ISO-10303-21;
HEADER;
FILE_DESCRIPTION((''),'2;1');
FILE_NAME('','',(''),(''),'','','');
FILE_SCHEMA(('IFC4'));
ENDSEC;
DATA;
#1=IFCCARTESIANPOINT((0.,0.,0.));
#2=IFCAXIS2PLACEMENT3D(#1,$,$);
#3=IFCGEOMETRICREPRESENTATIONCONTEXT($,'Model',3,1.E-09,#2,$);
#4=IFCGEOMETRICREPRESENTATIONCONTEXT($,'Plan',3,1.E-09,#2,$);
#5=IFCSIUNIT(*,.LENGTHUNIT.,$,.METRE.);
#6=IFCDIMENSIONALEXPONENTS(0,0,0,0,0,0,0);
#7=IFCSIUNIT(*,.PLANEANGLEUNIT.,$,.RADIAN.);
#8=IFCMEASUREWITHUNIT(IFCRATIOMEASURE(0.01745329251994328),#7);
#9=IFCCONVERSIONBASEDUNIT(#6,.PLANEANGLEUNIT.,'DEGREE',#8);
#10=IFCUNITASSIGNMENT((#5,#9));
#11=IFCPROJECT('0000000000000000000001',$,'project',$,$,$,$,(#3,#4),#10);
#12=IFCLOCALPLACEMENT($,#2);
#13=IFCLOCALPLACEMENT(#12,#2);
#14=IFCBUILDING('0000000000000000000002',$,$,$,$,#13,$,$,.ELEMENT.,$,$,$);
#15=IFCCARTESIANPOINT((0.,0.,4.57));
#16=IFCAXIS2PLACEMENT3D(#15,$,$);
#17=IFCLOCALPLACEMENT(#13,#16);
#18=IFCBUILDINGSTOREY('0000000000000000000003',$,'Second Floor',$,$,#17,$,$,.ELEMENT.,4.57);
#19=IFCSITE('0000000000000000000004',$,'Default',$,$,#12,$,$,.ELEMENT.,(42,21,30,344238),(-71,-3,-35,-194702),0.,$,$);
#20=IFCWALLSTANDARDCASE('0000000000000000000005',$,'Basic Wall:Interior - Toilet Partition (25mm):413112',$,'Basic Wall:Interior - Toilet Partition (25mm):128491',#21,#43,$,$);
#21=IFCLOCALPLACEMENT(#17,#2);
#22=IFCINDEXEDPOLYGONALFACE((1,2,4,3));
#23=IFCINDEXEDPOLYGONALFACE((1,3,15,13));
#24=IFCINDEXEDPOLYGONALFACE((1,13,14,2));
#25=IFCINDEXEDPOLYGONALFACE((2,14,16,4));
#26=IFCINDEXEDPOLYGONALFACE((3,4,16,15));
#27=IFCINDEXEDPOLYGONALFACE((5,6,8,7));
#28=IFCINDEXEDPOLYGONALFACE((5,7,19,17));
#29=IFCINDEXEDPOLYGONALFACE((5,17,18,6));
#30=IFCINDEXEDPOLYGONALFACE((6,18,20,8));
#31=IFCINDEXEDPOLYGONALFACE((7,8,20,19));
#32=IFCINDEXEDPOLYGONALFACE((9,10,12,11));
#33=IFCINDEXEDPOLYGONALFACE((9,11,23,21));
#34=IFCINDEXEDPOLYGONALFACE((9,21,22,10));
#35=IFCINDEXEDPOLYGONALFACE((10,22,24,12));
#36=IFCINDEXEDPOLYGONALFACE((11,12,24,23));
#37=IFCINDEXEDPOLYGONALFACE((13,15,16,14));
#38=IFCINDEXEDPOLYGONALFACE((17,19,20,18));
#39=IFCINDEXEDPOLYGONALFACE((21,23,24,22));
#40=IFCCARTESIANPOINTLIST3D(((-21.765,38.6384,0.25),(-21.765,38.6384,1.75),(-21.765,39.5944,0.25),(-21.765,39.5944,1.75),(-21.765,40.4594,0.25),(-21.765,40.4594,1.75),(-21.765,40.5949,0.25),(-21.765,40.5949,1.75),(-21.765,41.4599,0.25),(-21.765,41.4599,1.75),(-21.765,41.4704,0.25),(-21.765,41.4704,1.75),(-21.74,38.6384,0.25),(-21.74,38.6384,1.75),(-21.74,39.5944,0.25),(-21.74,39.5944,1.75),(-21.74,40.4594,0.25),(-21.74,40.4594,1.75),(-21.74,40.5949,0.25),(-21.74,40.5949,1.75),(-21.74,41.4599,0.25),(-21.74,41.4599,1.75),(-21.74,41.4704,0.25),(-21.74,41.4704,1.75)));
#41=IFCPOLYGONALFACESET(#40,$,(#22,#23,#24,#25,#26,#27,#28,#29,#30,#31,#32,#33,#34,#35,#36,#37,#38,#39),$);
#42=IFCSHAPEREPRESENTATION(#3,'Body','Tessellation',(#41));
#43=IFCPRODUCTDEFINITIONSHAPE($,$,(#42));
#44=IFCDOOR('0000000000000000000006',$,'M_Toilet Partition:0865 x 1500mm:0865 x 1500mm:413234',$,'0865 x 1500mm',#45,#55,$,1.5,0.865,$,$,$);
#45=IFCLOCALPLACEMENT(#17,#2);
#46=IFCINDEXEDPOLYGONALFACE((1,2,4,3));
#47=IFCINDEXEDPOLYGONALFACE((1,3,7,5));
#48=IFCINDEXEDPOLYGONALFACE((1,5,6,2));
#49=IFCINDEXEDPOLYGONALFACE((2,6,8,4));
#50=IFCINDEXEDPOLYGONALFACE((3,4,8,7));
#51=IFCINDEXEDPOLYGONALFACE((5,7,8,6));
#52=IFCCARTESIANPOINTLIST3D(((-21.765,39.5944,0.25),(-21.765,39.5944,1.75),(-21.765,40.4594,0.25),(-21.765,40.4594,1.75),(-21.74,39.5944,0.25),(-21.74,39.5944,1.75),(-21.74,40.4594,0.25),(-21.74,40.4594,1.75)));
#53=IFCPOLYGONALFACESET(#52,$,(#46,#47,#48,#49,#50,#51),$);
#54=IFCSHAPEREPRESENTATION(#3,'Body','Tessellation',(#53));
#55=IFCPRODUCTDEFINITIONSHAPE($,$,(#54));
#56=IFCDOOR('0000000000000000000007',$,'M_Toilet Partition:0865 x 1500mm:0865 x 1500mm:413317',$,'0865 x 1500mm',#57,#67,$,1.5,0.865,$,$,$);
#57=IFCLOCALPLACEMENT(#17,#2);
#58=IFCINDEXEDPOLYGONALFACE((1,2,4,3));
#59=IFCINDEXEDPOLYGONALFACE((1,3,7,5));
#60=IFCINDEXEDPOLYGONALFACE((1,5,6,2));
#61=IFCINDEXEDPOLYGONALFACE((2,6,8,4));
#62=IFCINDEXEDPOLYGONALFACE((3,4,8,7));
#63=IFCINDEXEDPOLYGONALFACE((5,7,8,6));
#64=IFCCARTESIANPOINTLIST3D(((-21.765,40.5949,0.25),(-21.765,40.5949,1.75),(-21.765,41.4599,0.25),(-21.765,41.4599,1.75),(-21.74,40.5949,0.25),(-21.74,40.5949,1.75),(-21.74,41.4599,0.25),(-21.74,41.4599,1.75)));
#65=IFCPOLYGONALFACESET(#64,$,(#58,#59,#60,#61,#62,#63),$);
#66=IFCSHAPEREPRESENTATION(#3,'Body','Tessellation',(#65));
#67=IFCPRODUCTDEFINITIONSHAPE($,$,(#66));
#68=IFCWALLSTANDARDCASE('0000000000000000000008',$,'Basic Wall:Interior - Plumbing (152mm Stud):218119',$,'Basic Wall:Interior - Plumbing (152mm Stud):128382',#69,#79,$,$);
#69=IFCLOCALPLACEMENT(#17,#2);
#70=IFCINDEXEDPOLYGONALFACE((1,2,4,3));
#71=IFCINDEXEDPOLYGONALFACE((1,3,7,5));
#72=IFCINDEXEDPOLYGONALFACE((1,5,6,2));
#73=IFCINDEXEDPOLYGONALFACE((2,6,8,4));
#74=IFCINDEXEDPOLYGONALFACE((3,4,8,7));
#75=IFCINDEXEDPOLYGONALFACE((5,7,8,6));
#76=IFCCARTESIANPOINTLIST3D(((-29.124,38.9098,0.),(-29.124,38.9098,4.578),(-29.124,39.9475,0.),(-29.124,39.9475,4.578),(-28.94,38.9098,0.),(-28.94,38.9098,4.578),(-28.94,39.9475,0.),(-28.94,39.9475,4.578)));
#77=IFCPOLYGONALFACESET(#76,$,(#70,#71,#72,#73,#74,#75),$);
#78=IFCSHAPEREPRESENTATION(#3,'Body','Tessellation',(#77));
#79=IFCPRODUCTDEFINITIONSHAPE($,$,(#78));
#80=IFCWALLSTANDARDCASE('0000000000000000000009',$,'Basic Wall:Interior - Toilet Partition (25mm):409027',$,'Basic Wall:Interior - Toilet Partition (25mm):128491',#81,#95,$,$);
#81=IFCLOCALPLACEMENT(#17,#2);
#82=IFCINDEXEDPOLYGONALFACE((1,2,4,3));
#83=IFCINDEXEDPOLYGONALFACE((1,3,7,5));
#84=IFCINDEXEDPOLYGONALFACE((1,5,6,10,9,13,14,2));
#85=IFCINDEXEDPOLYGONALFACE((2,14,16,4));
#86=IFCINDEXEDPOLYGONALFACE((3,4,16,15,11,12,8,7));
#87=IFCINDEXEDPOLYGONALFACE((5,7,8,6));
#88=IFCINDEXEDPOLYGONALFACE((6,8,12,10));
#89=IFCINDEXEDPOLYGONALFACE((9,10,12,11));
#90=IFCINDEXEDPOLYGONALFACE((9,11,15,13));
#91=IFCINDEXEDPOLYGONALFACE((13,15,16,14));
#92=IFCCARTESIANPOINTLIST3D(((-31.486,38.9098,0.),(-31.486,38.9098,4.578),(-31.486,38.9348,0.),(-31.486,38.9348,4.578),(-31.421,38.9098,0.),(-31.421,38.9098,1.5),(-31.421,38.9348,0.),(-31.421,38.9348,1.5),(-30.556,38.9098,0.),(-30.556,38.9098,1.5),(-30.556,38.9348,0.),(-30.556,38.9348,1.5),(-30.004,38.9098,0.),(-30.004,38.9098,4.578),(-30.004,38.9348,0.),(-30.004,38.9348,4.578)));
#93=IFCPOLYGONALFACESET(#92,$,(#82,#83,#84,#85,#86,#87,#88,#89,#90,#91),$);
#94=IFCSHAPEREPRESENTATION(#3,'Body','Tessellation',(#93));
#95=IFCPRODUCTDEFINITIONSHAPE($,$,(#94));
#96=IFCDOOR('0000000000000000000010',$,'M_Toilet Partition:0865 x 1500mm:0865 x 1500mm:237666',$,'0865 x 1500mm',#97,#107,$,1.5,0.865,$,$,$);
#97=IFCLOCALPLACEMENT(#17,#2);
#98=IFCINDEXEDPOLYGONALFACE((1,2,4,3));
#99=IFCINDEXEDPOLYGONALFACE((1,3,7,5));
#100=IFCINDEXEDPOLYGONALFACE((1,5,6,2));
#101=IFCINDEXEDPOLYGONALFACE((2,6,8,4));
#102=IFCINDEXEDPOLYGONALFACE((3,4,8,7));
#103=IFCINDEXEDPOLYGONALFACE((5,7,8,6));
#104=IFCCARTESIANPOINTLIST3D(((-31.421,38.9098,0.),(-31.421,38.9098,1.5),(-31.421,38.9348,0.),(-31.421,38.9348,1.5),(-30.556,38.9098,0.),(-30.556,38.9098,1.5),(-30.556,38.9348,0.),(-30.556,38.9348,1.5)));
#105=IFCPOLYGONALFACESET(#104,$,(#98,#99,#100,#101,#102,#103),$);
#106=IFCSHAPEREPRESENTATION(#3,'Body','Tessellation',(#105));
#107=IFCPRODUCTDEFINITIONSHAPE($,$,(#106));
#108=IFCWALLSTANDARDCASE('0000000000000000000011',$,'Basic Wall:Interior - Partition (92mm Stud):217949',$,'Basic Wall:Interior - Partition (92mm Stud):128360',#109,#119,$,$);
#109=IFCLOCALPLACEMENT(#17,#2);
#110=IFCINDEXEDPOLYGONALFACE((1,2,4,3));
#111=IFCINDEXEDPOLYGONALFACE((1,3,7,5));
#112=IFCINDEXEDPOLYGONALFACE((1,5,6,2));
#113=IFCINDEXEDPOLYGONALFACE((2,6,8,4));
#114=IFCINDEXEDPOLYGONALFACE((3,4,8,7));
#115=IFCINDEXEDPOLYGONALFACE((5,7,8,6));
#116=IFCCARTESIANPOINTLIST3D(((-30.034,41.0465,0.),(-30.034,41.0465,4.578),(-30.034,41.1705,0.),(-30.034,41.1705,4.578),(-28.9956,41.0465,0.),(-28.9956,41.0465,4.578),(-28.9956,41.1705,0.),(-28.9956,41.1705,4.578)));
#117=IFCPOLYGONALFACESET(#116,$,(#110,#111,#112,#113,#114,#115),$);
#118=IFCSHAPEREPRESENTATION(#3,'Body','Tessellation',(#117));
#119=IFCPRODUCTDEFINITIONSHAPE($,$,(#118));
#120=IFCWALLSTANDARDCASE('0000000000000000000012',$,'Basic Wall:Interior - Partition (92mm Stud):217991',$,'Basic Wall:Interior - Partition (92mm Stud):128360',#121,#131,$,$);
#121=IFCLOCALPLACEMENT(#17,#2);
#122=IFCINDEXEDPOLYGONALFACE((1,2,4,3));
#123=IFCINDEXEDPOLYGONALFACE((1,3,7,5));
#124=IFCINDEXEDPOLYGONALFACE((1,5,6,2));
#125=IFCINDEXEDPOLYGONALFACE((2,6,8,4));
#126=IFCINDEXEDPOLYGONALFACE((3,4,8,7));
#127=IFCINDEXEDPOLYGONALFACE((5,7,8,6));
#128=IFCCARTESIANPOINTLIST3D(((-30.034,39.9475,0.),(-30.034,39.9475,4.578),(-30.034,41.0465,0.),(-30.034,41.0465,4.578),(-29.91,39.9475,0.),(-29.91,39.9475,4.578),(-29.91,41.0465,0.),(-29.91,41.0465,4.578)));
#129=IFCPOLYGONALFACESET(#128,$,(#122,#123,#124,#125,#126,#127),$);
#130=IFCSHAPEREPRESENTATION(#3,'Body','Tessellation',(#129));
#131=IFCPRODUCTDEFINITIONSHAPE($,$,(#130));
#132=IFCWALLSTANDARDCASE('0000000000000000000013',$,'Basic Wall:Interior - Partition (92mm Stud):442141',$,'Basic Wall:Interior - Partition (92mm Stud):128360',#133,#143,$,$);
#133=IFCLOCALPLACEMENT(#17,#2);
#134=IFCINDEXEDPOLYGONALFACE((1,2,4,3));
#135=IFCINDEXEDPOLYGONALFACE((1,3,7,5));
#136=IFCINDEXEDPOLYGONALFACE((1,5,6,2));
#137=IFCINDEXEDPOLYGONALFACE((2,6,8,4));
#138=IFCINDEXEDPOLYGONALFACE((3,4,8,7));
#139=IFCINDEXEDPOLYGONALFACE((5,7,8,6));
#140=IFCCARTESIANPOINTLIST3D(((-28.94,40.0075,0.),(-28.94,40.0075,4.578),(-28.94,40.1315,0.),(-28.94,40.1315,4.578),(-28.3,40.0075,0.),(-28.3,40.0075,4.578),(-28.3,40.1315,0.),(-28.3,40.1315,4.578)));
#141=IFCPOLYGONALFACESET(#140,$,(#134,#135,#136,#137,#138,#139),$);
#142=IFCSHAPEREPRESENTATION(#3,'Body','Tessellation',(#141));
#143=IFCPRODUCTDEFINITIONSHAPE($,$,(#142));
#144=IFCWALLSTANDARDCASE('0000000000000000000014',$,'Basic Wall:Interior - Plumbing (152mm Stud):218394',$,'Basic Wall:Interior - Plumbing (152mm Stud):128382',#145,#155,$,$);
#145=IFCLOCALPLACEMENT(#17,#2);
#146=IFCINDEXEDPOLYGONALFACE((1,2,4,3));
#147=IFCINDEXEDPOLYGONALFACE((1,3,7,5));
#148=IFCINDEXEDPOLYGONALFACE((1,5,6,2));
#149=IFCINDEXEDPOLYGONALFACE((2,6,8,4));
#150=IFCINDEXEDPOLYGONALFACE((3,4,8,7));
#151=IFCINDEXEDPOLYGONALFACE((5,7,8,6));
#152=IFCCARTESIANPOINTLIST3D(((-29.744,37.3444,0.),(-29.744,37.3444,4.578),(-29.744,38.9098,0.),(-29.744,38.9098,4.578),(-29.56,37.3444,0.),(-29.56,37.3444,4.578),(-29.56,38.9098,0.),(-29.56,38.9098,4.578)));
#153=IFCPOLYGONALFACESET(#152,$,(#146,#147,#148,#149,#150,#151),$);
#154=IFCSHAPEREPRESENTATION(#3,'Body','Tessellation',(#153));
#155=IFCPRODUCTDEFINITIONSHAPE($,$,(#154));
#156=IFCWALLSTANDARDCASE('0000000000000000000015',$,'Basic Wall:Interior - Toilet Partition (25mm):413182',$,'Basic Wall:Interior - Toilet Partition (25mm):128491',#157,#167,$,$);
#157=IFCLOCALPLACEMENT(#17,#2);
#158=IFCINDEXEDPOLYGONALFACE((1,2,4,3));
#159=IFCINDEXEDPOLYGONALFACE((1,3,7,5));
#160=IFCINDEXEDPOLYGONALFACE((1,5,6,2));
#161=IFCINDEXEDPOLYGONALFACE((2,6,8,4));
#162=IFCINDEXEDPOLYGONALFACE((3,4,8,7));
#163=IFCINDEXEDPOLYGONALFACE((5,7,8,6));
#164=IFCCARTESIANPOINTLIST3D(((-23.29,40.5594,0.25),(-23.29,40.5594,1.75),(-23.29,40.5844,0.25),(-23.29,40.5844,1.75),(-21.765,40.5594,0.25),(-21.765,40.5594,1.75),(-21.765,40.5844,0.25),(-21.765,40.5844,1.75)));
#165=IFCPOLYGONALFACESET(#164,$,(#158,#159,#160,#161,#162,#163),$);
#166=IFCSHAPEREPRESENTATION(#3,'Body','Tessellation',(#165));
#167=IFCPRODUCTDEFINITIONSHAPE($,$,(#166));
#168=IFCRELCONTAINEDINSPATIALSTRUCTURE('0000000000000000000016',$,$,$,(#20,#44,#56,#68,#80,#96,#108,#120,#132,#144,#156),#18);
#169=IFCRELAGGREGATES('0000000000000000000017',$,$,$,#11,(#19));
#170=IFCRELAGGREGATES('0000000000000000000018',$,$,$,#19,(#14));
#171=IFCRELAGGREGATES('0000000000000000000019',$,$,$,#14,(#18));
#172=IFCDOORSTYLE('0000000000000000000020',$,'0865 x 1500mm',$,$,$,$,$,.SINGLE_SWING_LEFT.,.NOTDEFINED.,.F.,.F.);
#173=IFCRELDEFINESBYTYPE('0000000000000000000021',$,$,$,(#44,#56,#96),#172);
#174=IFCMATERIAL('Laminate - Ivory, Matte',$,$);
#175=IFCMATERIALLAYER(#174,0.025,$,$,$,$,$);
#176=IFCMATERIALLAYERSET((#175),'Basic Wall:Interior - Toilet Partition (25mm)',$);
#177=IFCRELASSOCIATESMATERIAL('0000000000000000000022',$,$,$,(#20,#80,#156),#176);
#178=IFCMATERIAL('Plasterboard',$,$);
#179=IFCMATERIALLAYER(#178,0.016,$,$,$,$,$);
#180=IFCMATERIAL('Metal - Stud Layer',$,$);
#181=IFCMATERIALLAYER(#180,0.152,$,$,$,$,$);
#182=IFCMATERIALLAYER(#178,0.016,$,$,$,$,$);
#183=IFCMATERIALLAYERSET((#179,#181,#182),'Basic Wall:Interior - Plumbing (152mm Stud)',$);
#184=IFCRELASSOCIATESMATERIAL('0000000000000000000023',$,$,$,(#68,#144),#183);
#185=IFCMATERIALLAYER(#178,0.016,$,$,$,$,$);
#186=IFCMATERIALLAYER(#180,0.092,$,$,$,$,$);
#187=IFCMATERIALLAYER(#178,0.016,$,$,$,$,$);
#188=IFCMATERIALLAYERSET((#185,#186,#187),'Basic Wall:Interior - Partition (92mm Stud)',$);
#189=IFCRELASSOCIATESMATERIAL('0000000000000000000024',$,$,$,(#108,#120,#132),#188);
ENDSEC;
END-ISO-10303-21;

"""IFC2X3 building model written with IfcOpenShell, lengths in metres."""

from ifc_helpers import new_model, entity, si_unit, converted_unit, frame, frame_2d, origin, origin_2d_with_axis, place, context, project, spatial, rectangle, extrude, source, transform, mapped, material, layer, layer_set, layer_usage, type_object, type_shapes, element, fill, save


model = new_model("IFC2X3")

# Units and contexts
model_context = context("Model", 3, precision=1e-09, world=origin())
plan_context = context("Plan", 3, precision=1e-09, world=origin())
ifc_project = project(units=[si_unit("LENGTHUNIT", "METRE"), converted_unit("PLANEANGLEUNIT", "DEGREE", entity("IfcRatioMeasure", 0.01745329251994328), si_unit("PLANEANGLEUNIT", "RADIAN"), dimensions=[0, 0, 0, 0, 0, 0, 0])], contexts=[model_context, plan_context])

# Site, building, storey
site_placement = place(None, origin())
site = spatial("IfcSite", under=ifc_project, at=site_placement, Name="Default", CompositionType="ELEMENT", RefLatitude=(42, 21, 30, 344238), RefLongitude=(-71, -3, -35, -194702), RefElevation=0.0)
building_placement = place(site_placement, origin())
building = spatial("IfcBuilding", under=site, at=building_placement, CompositionType="ELEMENT")
storey_placement = place(building_placement, frame((0.0, 0.0, 4.57)))
storey = spatial("IfcBuildingStorey", under=building, at=storey_placement, Name="Second Floor", CompositionType="ELEMENT", Elevation=4.57)

# Shared definitions
ifc_material_1 = material(Name="Plasterboard")
ifc_layer_1 = layer(ifc_material_1, 0.016)
ifc_material_2 = material(Name="Metal - Stud Layer")
ifc_layer_2 = layer(ifc_material_2, 0.092)
ifc_layer_3 = layer(ifc_material_1, 0.016)
ifc_layer_set_1 = layer_set([ifc_layer_1, ifc_layer_2, ifc_layer_3], Name="Basic Wall:Interior - Partition (92mm Stud)")
ifc_layer_usage_1 = layer_usage(ifc_layer_set_1, "AXIS2", "NEGATIVE", 0.062)

# Shared definitions
ifc_layer_4 = layer(ifc_material_1, 0.016)
ifc_layer_5 = layer(ifc_material_2, 0.152)
ifc_layer_6 = layer(ifc_material_1, 0.016)
ifc_layer_set_2 = layer_set([ifc_layer_4, ifc_layer_5, ifc_layer_6], Name="Basic Wall:Interior - Plumbing (152mm Stud)")
ifc_layer_usage_2 = layer_usage(ifc_layer_set_2, "AXIS2", "NEGATIVE", 0.092)

# Wall, openings, doors
ifc_material_3 = material(Name="Laminate - Ivory, Matte")
ifc_layer_7 = layer(ifc_material_3, 0.025)
ifc_layer_set_3 = layer_set([ifc_layer_7], Name="Basic Wall:Interior - Toilet Partition (25mm)")
ifc_layer_usage_3 = layer_usage(ifc_layer_set_3, "AXIS2", "NEGATIVE", 0.0125)
wall_1_placement = place(storey_placement, frame((-21.7525, 38.6384, 0.25), z_axis=(0.0, 0.0, 1.0), x_axis=(0.0, 1.0, 0.0)))
wall_1 = element("IfcWallStandardCase", 1, at=wall_1_placement, inside=storey, material=ifc_layer_usage_3, Name="Basic Wall:Interior - Toilet Partition (25mm):413112", ObjectType="Basic Wall:Interior - Toilet Partition (25mm):128491", context=model_context, shape_type="SweptSolid", body=[
    extrude(rectangle(XDim=2.8321, YDim=0.025, at=frame_2d((1.416, 0.0), x_axis=(-1.0, 0.0))), origin(), (0.0, 0.0, 1.0), 1.5),
])
opening_1_placement = place(wall_1_placement, frame((1.8211, 0.0125, 0.0)))
opening_1 = element("IfcOpeningElement", 2, at=opening_1_placement, cuts=wall_1, ObjectType="Opening", context=model_context, shape_type="SweptSolid", body=[
    extrude(rectangle(XDim=0.865, YDim=1.5, at=frame_2d((0.75, 0.4325), x_axis=(0.0, -1.0))), frame((0.0, 0.0, 0.0), z_axis=(0.0, -1.0, 0.0), x_axis=(0.0, 0.0, 1.0)), (0.0, 0.0, 1.0), 0.025),
])
opening_2_placement = place(wall_1_placement, frame((1.9566, -0.0125, 0.0)))
opening_2 = element("IfcOpeningElement", 3, at=opening_2_placement, cuts=wall_1, ObjectType="Opening", context=model_context, shape_type="SweptSolid", body=[
    extrude(rectangle(XDim=0.865, YDim=1.5, at=frame_2d((0.75, 0.4325), x_axis=(0.0, -1.0))), frame((0.0, 0.0, 0.0), z_axis=(0.0, 1.0, 0.0), x_axis=(0.0, 0.0, 1.0)), (0.0, 0.0, 1.0), 0.025),
])
door_style_1 = type_object("IfcDoorStyle", Name="0865 x 1500mm", ConstructionType="NOTDEFINED", OperationType="SINGLE_SWING_LEFT", ParameterTakesPrecedence=False, Sizeable=False)
shared_shape_1 = source(origin(), model_context, "Body", "SweptSolid", [
    extrude(rectangle(XDim=0.865, YDim=0.025, at=origin_2d_with_axis()), frame((0.4325, 0.0125, 0.0)), (0.0, 0.0, 1.0), 1.5),
])
type_shapes(door_style_1, [shared_shape_1])
door_1_placement = place(opening_1_placement, frame((0.0, 0.0, 0.0), z_axis=(0.0, 0.0, 1.0), x_axis=(-1.0, 0.0, 0.0)))
door_1 = element("IfcDoor", 4, at=door_1_placement, inside=storey, type_object=door_style_1, Name="M_Toilet Partition:0865 x 1500mm:0865 x 1500mm:413234", ObjectType="0865 x 1500mm", OverallHeight=1.5, OverallWidth=0.865, context=model_context, shape_type="MappedRepresentation", body=[
    mapped(shared_shape_1, transform((0.0, 0.0, 0.0), scale=1.0)),
])
fill(opening_1, door_1)
door_2_placement = place(opening_2_placement, origin())
door_2 = element("IfcDoor", 5, at=door_2_placement, inside=storey, type_object=door_style_1, Name="M_Toilet Partition:0865 x 1500mm:0865 x 1500mm:413317", ObjectType="0865 x 1500mm", OverallHeight=1.5, OverallWidth=0.865, context=model_context, shape_type="MappedRepresentation", body=[
    mapped(shared_shape_1, transform((0.0, 0.0, 0.0), scale=1.0)),
])
fill(opening_2, door_2)

# Wall
wall_2_placement = place(storey_placement, frame((-29.032, 39.9475, 0.0), z_axis=(0.0, 0.0, 1.0), x_axis=(0.0, -1.0, 0.0)))
element("IfcWallStandardCase", 6, at=wall_2_placement, inside=storey, material=ifc_layer_usage_2, Name="Basic Wall:Interior - Plumbing (152mm Stud):218119", ObjectType="Basic Wall:Interior - Plumbing (152mm Stud):128382", context=model_context, shape_type="SweptSolid", body=[
    extrude(rectangle(XDim=1.0378, YDim=0.184, at=frame_2d((0.5189, 0.0), x_axis=(-1.0, 0.0))), origin(), (0.0, 0.0, 1.0), 4.578),
])

# Wall, opening, door
wall_3_placement = place(storey_placement, frame((-30.004, 38.9223, 0.0), z_axis=(0.0, 0.0, 1.0), x_axis=(-1.0, 0.0, 0.0)))
wall_3 = element("IfcWallStandardCase", 7, at=wall_3_placement, inside=storey, material=ifc_layer_usage_3, Name="Basic Wall:Interior - Toilet Partition (25mm):409027", ObjectType="Basic Wall:Interior - Toilet Partition (25mm):128491", context=model_context, shape_type="SweptSolid", body=[
    extrude(rectangle(XDim=1.482, YDim=0.025, at=frame_2d((0.741, 0.0), x_axis=(-1.0, 0.0))), origin(), (0.0, 0.0, 1.0), 4.578),
])
opening_3_placement = place(wall_3_placement, frame((1.417, 0.0125, 0.0)))
opening_3 = element("IfcOpeningElement", 8, at=opening_3_placement, cuts=wall_3, ObjectType="Opening", context=model_context, shape_type="SweptSolid", body=[
    extrude(rectangle(XDim=0.865, YDim=1.5, at=frame_2d((0.75, 0.4325), x_axis=(0.0, -1.0))), frame((0.0, 0.0, 0.0), z_axis=(0.0, -1.0, 0.0), x_axis=(0.0, 0.0, 1.0)), (0.0, 0.0, 1.0), 0.025),
])
door_3_placement = place(opening_3_placement, frame((0.0, 0.0, 0.0), z_axis=(0.0, 0.0, 1.0), x_axis=(-1.0, 0.0, 0.0)))
door_3 = element("IfcDoor", 9, at=door_3_placement, inside=storey, type_object=door_style_1, Name="M_Toilet Partition:0865 x 1500mm:0865 x 1500mm:237666", ObjectType="0865 x 1500mm", OverallHeight=1.5, OverallWidth=0.865, context=model_context, shape_type="MappedRepresentation", body=[
    mapped(shared_shape_1, transform((0.0, 0.0, 0.0), scale=1.0)),
])
fill(opening_3, door_3)

# Walls
wall_4_placement = place(storey_placement, frame((-28.9956, 41.1085, 0.0), z_axis=(0.0, 0.0, 1.0), x_axis=(-1.0, 0.0, 0.0)))
element("IfcWallStandardCase", 10, at=wall_4_placement, inside=storey, material=ifc_layer_usage_1, Name="Basic Wall:Interior - Partition (92mm Stud):217949", ObjectType="Basic Wall:Interior - Partition (92mm Stud):128360", context=model_context, shape_type="SweptSolid", body=[
    extrude(rectangle(XDim=1.0384, YDim=0.124, at=frame_2d((0.5192, 0.0), x_axis=(-1.0, 0.0))), origin(), (0.0, 0.0, 1.0), 4.578),
])
wall_5_placement = place(storey_placement, frame((-29.972, 41.0465, 0.0), z_axis=(0.0, 0.0, 1.0), x_axis=(0.0, -1.0, 0.0)))
element("IfcWallStandardCase", 11, at=wall_5_placement, inside=storey, material=ifc_layer_usage_1, Name="Basic Wall:Interior - Partition (92mm Stud):217991", ObjectType="Basic Wall:Interior - Partition (92mm Stud):128360", context=model_context, shape_type="SweptSolid", body=[
    extrude(rectangle(XDim=1.099, YDim=0.124, at=frame_2d((0.5495, 0.0), x_axis=(-1.0, 0.0))), origin(), (0.0, 0.0, 1.0), 4.578),
])
wall_6_placement = place(storey_placement, frame((-28.94, 40.0695, 0.0)))
element("IfcWallStandardCase", 12, at=wall_6_placement, inside=storey, material=ifc_layer_usage_1, Name="Basic Wall:Interior - Partition (92mm Stud):442141", ObjectType="Basic Wall:Interior - Partition (92mm Stud):128360", context=model_context, shape_type="SweptSolid", body=[
    extrude(rectangle(XDim=0.64, YDim=0.124, at=frame_2d((0.32, 0.0), x_axis=(-1.0, 0.0))), origin(), (0.0, 0.0, 1.0), 4.578),
])
wall_7_placement = place(storey_placement, frame((-29.652, 38.9098, 0.0), z_axis=(0.0, 0.0, 1.0), x_axis=(0.0, -1.0, 0.0)))
element("IfcWallStandardCase", 13, at=wall_7_placement, inside=storey, material=ifc_layer_usage_2, Name="Basic Wall:Interior - Plumbing (152mm Stud):218394", ObjectType="Basic Wall:Interior - Plumbing (152mm Stud):128382", context=model_context, shape_type="SweptSolid", body=[
    extrude(rectangle(XDim=1.5653, YDim=0.184, at=frame_2d((0.7827, 0.0), x_axis=(-1.0, 0.0))), origin(), (0.0, 0.0, 1.0), 4.578),
])
wall_8_placement = place(storey_placement, frame((-23.29, 40.5719, 0.25)))
element("IfcWallStandardCase", 14, at=wall_8_placement, inside=storey, material=ifc_layer_usage_3, Name="Basic Wall:Interior - Toilet Partition (25mm):413182", ObjectType="Basic Wall:Interior - Toilet Partition (25mm):128491", context=model_context, shape_type="SweptSolid", body=[
    extrude(rectangle(XDim=1.525, YDim=0.025, at=frame_2d((0.7625, 0.0), x_axis=(-1.0, 0.0))), origin(), (0.0, 0.0, 1.0), 1.5),
])

save(model, "model.ifc")
